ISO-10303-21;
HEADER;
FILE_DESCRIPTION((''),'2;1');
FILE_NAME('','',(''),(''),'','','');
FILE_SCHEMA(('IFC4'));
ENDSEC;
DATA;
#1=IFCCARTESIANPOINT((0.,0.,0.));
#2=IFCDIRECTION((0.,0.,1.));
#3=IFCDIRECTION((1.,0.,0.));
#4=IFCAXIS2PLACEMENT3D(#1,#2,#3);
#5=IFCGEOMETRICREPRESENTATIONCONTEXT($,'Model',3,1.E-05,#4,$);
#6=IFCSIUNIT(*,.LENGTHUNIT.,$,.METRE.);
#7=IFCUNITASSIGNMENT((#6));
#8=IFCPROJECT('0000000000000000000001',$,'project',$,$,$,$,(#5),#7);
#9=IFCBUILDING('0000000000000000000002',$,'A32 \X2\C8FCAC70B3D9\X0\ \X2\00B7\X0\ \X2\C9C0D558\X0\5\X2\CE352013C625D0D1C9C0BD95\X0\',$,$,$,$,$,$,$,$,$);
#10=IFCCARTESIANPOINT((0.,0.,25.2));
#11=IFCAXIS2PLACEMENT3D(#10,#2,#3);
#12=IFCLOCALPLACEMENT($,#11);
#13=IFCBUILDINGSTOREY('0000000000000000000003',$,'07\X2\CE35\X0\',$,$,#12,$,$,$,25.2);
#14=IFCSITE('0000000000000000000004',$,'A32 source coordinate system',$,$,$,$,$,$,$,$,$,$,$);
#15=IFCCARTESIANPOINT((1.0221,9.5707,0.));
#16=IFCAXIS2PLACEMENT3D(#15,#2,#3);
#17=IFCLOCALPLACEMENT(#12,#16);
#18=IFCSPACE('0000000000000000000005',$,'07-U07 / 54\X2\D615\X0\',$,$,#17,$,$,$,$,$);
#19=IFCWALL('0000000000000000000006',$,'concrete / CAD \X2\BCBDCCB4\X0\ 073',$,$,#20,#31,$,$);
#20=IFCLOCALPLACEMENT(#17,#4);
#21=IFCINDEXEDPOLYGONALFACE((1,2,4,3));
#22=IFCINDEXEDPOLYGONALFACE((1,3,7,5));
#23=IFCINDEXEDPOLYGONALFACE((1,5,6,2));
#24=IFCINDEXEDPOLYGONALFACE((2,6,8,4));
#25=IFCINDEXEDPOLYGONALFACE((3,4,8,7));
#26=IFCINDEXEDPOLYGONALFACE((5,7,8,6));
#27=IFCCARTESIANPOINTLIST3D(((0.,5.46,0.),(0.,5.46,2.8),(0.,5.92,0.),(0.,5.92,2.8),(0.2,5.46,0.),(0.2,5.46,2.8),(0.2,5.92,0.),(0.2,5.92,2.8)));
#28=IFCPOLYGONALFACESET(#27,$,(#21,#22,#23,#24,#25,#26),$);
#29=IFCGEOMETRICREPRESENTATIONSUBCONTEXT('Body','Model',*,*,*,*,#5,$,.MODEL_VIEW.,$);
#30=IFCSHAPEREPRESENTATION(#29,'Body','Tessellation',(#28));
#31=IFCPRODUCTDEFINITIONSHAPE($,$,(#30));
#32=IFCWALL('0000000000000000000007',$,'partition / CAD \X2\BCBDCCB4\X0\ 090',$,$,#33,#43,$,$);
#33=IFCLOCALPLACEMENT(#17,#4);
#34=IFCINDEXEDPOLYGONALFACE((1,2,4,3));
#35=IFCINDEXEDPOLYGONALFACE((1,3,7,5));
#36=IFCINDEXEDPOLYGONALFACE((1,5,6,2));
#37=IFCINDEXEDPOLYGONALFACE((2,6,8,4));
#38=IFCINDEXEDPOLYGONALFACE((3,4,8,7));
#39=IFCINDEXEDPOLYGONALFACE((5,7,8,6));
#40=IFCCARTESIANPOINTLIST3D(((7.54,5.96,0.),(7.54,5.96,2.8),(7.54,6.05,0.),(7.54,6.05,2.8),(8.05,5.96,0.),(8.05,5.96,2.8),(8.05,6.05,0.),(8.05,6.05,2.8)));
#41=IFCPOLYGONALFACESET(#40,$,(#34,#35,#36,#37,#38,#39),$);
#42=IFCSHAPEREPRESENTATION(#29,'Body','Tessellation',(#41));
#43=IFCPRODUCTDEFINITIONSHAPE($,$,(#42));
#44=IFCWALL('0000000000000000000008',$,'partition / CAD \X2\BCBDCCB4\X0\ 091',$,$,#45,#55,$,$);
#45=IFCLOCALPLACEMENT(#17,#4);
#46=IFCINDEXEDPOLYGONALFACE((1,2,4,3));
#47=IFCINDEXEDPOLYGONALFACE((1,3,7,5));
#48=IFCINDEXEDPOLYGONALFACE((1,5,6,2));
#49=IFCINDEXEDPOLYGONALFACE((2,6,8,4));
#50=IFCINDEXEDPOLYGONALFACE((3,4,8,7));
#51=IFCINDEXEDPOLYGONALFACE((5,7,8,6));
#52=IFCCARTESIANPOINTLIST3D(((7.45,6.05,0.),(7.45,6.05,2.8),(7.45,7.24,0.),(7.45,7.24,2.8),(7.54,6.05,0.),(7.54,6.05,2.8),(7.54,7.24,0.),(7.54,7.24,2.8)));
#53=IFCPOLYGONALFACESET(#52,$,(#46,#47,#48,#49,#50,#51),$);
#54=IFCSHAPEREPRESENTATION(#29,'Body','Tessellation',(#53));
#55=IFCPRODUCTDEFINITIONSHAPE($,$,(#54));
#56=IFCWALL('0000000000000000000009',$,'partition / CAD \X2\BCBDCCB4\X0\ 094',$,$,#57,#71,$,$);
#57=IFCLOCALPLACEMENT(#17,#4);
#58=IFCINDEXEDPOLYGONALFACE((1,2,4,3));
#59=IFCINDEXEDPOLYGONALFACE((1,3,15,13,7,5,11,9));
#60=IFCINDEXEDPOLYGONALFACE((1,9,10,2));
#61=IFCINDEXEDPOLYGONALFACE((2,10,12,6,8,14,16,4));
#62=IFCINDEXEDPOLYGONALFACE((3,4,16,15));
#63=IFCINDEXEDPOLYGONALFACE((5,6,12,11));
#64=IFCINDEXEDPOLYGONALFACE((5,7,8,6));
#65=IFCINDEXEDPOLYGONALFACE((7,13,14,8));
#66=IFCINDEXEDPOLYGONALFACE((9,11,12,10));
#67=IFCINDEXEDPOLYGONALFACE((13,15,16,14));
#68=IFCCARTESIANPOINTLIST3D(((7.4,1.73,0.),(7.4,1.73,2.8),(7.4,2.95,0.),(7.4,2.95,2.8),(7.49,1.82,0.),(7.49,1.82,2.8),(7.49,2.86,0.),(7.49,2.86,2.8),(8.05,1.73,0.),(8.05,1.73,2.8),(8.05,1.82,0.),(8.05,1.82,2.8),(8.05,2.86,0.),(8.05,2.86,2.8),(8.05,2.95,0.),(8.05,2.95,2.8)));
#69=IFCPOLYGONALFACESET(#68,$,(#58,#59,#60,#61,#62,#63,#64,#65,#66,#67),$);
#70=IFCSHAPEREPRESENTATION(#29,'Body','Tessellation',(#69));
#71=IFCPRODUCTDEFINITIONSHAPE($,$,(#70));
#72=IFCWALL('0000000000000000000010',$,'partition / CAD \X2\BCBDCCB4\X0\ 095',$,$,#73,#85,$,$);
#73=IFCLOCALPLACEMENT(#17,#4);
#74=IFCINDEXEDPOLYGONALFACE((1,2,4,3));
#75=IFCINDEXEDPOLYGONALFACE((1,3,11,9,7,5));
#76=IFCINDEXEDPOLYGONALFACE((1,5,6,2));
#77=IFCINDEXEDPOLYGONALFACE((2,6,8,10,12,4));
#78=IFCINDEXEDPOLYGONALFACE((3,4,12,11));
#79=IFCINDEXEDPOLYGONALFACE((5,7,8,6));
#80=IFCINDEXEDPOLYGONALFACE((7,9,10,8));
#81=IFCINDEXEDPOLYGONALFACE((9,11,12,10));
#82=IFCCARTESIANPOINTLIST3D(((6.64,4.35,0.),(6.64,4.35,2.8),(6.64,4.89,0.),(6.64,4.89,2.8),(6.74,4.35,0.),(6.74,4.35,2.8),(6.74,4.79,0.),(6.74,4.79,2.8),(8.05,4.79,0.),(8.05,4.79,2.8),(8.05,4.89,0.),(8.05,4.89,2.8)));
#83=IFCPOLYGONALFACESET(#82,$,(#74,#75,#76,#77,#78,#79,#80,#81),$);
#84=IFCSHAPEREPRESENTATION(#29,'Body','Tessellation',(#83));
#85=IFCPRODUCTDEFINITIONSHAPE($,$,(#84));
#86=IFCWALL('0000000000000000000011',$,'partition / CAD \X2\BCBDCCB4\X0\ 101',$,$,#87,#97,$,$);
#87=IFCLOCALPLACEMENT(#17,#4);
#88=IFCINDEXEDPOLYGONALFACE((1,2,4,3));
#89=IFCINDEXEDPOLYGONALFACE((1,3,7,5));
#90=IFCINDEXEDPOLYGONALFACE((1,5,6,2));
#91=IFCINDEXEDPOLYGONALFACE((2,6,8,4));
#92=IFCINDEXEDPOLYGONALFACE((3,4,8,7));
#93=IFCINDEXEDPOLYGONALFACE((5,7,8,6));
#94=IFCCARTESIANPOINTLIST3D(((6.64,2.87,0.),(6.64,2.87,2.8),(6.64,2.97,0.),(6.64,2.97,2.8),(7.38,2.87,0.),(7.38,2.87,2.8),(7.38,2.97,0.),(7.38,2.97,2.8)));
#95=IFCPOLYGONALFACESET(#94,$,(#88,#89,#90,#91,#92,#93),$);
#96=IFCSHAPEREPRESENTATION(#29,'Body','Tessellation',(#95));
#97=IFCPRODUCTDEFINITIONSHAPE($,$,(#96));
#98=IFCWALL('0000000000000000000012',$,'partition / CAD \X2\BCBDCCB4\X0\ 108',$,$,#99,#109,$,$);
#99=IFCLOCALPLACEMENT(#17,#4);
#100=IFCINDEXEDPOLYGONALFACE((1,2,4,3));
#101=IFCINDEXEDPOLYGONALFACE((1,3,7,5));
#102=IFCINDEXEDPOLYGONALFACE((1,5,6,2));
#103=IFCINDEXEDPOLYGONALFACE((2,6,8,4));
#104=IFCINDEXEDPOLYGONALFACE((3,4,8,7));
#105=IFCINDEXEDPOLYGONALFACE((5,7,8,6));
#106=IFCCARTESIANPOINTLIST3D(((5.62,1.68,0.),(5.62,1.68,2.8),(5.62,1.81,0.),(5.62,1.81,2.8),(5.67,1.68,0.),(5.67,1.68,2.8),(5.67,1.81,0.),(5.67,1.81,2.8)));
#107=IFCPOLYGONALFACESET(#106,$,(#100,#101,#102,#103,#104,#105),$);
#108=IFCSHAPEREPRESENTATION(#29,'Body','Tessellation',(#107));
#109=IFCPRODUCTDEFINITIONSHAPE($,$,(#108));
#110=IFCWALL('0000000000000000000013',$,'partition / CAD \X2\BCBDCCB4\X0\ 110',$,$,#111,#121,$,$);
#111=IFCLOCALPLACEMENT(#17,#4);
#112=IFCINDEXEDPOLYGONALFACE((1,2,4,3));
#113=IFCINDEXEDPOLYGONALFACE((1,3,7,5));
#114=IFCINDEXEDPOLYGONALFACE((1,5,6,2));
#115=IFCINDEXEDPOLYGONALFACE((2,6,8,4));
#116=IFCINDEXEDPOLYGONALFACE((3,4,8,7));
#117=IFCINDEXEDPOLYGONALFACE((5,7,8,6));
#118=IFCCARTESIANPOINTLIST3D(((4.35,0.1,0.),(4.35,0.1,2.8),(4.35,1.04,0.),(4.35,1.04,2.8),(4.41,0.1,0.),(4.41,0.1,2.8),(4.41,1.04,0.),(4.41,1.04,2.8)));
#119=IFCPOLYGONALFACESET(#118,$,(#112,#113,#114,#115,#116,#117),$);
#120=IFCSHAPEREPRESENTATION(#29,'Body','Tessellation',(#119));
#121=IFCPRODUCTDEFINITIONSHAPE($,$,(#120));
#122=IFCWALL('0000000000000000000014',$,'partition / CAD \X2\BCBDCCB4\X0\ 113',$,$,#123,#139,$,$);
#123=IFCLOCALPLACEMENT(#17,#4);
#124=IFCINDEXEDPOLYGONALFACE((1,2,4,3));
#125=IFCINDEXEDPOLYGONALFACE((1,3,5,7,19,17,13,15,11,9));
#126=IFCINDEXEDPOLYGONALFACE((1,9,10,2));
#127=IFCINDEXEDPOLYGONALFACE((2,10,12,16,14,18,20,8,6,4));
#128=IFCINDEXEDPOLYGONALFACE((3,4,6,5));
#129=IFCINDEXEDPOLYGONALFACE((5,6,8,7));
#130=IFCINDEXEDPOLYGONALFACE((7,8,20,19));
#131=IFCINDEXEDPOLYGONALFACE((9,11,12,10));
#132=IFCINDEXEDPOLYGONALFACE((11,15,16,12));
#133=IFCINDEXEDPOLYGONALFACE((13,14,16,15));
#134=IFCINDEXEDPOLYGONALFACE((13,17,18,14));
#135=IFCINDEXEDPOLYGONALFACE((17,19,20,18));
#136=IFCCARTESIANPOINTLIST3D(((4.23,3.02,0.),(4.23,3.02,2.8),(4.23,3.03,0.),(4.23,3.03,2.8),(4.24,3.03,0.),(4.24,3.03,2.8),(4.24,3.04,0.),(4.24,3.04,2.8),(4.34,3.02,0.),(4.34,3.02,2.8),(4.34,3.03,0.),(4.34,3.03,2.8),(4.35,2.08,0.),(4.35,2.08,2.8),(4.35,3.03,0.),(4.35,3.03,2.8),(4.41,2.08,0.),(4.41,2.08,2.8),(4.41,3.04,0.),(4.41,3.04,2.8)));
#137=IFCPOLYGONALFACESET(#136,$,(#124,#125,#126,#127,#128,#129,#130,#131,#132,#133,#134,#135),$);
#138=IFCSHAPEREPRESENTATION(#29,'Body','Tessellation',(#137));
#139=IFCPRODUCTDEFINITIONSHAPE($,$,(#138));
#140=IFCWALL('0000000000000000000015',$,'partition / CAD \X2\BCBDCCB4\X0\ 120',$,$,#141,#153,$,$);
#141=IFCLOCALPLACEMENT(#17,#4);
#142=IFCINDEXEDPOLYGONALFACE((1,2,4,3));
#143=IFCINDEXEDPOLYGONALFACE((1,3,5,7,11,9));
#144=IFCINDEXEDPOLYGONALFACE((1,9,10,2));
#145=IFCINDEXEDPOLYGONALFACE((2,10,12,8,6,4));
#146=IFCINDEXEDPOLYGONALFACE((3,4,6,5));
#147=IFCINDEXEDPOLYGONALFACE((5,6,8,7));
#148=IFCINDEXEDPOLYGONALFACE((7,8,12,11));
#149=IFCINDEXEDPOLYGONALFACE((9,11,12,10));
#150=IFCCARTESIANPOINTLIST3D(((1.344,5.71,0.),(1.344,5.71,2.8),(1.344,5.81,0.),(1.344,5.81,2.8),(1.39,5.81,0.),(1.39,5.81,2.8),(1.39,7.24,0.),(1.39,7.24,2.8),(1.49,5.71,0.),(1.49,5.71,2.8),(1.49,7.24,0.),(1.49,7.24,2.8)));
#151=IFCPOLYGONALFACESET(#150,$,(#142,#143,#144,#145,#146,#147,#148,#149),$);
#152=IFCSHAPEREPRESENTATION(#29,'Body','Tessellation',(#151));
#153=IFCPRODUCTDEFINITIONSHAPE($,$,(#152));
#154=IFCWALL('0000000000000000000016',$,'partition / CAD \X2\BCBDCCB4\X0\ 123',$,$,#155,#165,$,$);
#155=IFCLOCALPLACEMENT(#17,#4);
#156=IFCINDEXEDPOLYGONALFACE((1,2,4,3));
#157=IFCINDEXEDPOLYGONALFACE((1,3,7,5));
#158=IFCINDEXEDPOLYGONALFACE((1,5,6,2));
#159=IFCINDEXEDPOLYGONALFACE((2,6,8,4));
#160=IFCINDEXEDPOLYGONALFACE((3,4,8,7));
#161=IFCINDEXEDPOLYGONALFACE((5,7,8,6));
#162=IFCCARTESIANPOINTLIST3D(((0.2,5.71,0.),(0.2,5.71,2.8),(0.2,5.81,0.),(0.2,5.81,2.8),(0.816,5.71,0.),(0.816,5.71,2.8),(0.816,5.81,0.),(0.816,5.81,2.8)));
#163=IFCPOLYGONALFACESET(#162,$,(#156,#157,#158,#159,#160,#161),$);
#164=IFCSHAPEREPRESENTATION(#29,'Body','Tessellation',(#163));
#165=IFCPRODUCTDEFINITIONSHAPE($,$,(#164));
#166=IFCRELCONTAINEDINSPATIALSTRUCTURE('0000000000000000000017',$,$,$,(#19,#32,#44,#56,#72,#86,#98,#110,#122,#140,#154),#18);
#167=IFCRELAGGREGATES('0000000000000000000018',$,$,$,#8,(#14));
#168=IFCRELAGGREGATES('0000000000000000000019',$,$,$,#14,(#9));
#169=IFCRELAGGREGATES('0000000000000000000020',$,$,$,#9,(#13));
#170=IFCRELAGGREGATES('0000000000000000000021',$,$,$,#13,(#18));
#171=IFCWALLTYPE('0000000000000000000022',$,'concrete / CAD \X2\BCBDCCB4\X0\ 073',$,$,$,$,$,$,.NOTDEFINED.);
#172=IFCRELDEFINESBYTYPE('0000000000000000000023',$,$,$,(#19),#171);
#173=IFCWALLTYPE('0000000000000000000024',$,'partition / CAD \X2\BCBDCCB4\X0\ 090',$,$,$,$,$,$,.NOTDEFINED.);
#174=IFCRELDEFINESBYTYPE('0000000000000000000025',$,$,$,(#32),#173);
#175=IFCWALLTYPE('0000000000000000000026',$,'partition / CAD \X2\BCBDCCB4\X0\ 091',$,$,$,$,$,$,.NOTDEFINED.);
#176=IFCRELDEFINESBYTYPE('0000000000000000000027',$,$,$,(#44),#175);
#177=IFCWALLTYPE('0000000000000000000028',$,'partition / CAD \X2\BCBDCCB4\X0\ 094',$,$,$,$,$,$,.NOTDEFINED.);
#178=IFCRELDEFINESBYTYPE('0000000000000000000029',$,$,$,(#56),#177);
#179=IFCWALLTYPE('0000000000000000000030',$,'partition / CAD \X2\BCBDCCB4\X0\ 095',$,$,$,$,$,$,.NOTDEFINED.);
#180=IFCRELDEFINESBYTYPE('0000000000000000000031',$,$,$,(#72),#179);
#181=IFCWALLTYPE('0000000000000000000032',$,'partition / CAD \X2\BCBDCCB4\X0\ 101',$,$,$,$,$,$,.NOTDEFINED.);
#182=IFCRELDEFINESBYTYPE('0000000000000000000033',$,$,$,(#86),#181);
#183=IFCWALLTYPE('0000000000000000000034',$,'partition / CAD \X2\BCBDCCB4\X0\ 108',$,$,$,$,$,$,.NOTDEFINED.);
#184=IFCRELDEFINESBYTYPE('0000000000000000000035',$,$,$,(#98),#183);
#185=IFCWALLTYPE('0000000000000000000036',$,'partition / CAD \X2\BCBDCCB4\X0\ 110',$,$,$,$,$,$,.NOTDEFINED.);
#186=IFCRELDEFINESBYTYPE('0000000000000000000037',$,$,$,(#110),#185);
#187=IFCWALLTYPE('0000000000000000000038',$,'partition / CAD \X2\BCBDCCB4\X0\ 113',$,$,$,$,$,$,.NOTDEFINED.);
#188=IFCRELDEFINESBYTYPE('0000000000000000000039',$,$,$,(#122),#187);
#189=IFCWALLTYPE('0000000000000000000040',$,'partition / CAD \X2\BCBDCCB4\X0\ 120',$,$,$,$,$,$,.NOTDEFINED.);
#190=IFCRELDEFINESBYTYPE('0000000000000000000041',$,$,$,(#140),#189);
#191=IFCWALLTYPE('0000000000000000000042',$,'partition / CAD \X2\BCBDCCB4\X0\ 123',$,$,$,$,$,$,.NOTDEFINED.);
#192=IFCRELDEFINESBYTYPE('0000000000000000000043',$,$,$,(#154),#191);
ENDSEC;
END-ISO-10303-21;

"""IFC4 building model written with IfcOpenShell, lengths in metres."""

from ifc_helpers import new_model, si_unit, frame, origin, origin_with_axes, place, context, subcontext, project, spatial, polyline, outline, extrude, source, transform, mapped, type_object, type_shapes, element, save


model = new_model("IFC4")

# Units and contexts
model_context = context("Model", 3, precision=1e-05, world=origin_with_axes())
body_context = subcontext(model_context, "Body", "Model", "MODEL_VIEW")
ifc_project = project(units=[si_unit("LENGTHUNIT", "METRE")], contexts=[model_context])

# Site, building, storey, space
site = spatial("IfcSite", under=ifc_project, Name="A32 source coordinate system")
building = spatial("IfcBuilding", under=site, Name="A32 주거동 · 지하5층–옥탑지붕")
storey_placement = place(None, frame((0.0, 0.0, 25.2), z_axis=(0.0, 0.0, 1.0), x_axis=(1.0, 0.0, 0.0)))
storey = spatial("IfcBuildingStorey", under=building, at=storey_placement, Name="07층", Elevation=25.2)
space_1_placement = place(storey_placement, frame((1.0221, 9.5707, 0.0), z_axis=(0.0, 0.0, 1.0), x_axis=(1.0, 0.0, 0.0)))
space_1 = spatial("IfcSpace", under=storey, at=space_1_placement, Name="07-U07 / 54형")

# Walls
wall_type_1 = type_object("IfcWallType", Name="concrete / CAD 벽체 073", PredefinedType="NOTDEFINED")
shared_shape_1 = source(origin(), body_context, "Body", "SweptSolid", [
    extrude(outline(polyline([(0.2, 5.92), (0.2, 5.46), (0.0, 5.46), (0.0, 5.92), (0.2, 5.92)])), origin(), (0.0, 0.0, 1.0), 2.8),
])
type_shapes(wall_type_1, [shared_shape_1])
wall_1_placement = place(space_1_placement, origin_with_axes())
element("IfcWall", 1, at=wall_1_placement, inside=space_1, type_object=wall_type_1, Name="concrete / CAD 벽체 073", context=body_context, shape_type="MappedRepresentation", body=[
    mapped(shared_shape_1, transform((0.0, 0.0, 0.0), scale=1.0)),
])
wall_type_2 = type_object("IfcWallType", Name="partition / CAD 벽체 090", PredefinedType="NOTDEFINED")
shared_shape_2 = source(origin(), body_context, "Body", "SweptSolid", [
    extrude(outline(polyline([(7.54, 5.96), (7.54, 6.05), (8.05, 6.05), (8.05, 5.96), (7.54, 5.96)])), origin(), (0.0, 0.0, 1.0), 2.8),
])
type_shapes(wall_type_2, [shared_shape_2])
wall_2_placement = place(space_1_placement, origin_with_axes())
element("IfcWall", 2, at=wall_2_placement, inside=space_1, type_object=wall_type_2, Name="partition / CAD 벽체 090", context=body_context, shape_type="MappedRepresentation", body=[
    mapped(shared_shape_2, transform((0.0, 0.0, 0.0), scale=1.0)),
])
wall_type_3 = type_object("IfcWallType", Name="partition / CAD 벽체 091", PredefinedType="NOTDEFINED")
shared_shape_3 = source(origin(), body_context, "Body", "SweptSolid", [
    extrude(outline(polyline([(7.54, 6.05), (7.45, 6.05), (7.45, 7.24), (7.54, 7.24), (7.54, 6.05)])), origin(), (0.0, 0.0, 1.0), 2.8),
])
type_shapes(wall_type_3, [shared_shape_3])
wall_3_placement = place(space_1_placement, origin_with_axes())
element("IfcWall", 3, at=wall_3_placement, inside=space_1, type_object=wall_type_3, Name="partition / CAD 벽체 091", context=body_context, shape_type="MappedRepresentation", body=[
    mapped(shared_shape_3, transform((0.0, 0.0, 0.0), scale=1.0)),
])
wall_type_4 = type_object("IfcWallType", Name="partition / CAD 벽체 094", PredefinedType="NOTDEFINED")
shared_shape_4 = source(origin(), body_context, "Body", "SweptSolid", [
    extrude(outline(polyline([(8.05, 1.73), (7.4, 1.73), (7.4, 2.95), (8.05, 2.95), (8.05, 2.86), (7.49, 2.86), (7.49, 1.82), (8.05, 1.82), (8.05, 1.73)])), origin(), (0.0, 0.0, 1.0), 2.8),
])
type_shapes(wall_type_4, [shared_shape_4])
wall_4_placement = place(space_1_placement, origin_with_axes())
element("IfcWall", 4, at=wall_4_placement, inside=space_1, type_object=wall_type_4, Name="partition / CAD 벽체 094", context=body_context, shape_type="MappedRepresentation", body=[
    mapped(shared_shape_4, transform((0.0, 0.0, 0.0), scale=1.0)),
])
wall_type_5 = type_object("IfcWallType", Name="partition / CAD 벽체 095", PredefinedType="NOTDEFINED")
shared_shape_5 = source(origin(), body_context, "Body", "SweptSolid", [
    extrude(outline(polyline([(6.64, 4.89), (8.05, 4.89), (8.05, 4.79), (6.74, 4.79), (6.74, 4.35), (6.64, 4.35), (6.64, 4.89)])), origin(), (0.0, 0.0, 1.0), 2.8),
])
type_shapes(wall_type_5, [shared_shape_5])
wall_5_placement = place(space_1_placement, origin_with_axes())
element("IfcWall", 5, at=wall_5_placement, inside=space_1, type_object=wall_type_5, Name="partition / CAD 벽체 095", context=body_context, shape_type="MappedRepresentation", body=[
    mapped(shared_shape_5, transform((0.0, 0.0, 0.0), scale=1.0)),
])
wall_type_6 = type_object("IfcWallType", Name="partition / CAD 벽체 101", PredefinedType="NOTDEFINED")
shared_shape_6 = source(origin(), body_context, "Body", "SweptSolid", [
    extrude(outline(polyline([(7.38, 2.97), (7.38, 2.87), (6.64, 2.87), (6.64, 2.97), (7.38, 2.97)])), origin(), (0.0, 0.0, 1.0), 2.8),
])
type_shapes(wall_type_6, [shared_shape_6])
wall_6_placement = place(space_1_placement, origin_with_axes())
element("IfcWall", 6, at=wall_6_placement, inside=space_1, type_object=wall_type_6, Name="partition / CAD 벽체 101", context=body_context, shape_type="MappedRepresentation", body=[
    mapped(shared_shape_6, transform((0.0, 0.0, 0.0), scale=1.0)),
])
wall_type_7 = type_object("IfcWallType", Name="partition / CAD 벽체 108", PredefinedType="NOTDEFINED")
shared_shape_7 = source(origin(), body_context, "Body", "SweptSolid", [
    extrude(outline(polyline([(5.67, 1.68), (5.62, 1.68), (5.62, 1.81), (5.67, 1.81), (5.67, 1.68)])), origin(), (0.0, 0.0, 1.0), 2.8),
])
type_shapes(wall_type_7, [shared_shape_7])
wall_7_placement = place(space_1_placement, origin_with_axes())
element("IfcWall", 7, at=wall_7_placement, inside=space_1, type_object=wall_type_7, Name="partition / CAD 벽체 108", context=body_context, shape_type="MappedRepresentation", body=[
    mapped(shared_shape_7, transform((0.0, 0.0, 0.0), scale=1.0)),
])
wall_type_8 = type_object("IfcWallType", Name="partition / CAD 벽체 110", PredefinedType="NOTDEFINED")
shared_shape_8 = source(origin(), body_context, "Body", "SweptSolid", [
    extrude(outline(polyline([(4.35, 1.04), (4.41, 1.04), (4.41, 0.1), (4.35, 0.1), (4.35, 1.04)])), origin(), (0.0, 0.0, 1.0), 2.8),
])
type_shapes(wall_type_8, [shared_shape_8])
wall_8_placement = place(space_1_placement, origin_with_axes())
element("IfcWall", 8, at=wall_8_placement, inside=space_1, type_object=wall_type_8, Name="partition / CAD 벽체 110", context=body_context, shape_type="MappedRepresentation", body=[
    mapped(shared_shape_8, transform((0.0, 0.0, 0.0), scale=1.0)),
])
wall_type_9 = type_object("IfcWallType", Name="partition / CAD 벽체 113", PredefinedType="NOTDEFINED")
shared_shape_9 = source(origin(), body_context, "Body", "SweptSolid", [
    extrude(outline(polyline([(4.24, 3.04), (4.41, 3.04), (4.41, 2.08), (4.35, 2.08), (4.35, 3.03), (4.34, 3.03), (4.34, 3.02), (4.23, 3.02), (4.23, 3.03), (4.24, 3.03), (4.24, 3.04)])), origin(), (0.0, 0.0, 1.0), 2.8),
])
type_shapes(wall_type_9, [shared_shape_9])
wall_9_placement = place(space_1_placement, origin_with_axes())
element("IfcWall", 9, at=wall_9_placement, inside=space_1, type_object=wall_type_9, Name="partition / CAD 벽체 113", context=body_context, shape_type="MappedRepresentation", body=[
    mapped(shared_shape_9, transform((0.0, 0.0, 0.0), scale=1.0)),
])
wall_type_10 = type_object("IfcWallType", Name="partition / CAD 벽체 120", PredefinedType="NOTDEFINED")
shared_shape_10 = source(origin(), body_context, "Body", "SweptSolid", [
    extrude(outline(polyline([(1.39, 7.24), (1.49, 7.24), (1.49, 5.71), (1.344, 5.71), (1.344, 5.81), (1.39, 5.81), (1.39, 7.24)])), origin(), (0.0, 0.0, 1.0), 2.8),
])
type_shapes(wall_type_10, [shared_shape_10])
wall_10_placement = place(space_1_placement, origin_with_axes())
element("IfcWall", 10, at=wall_10_placement, inside=space_1, type_object=wall_type_10, Name="partition / CAD 벽체 120", context=body_context, shape_type="MappedRepresentation", body=[
    mapped(shared_shape_10, transform((0.0, 0.0, 0.0), scale=1.0)),
])
wall_type_11 = type_object("IfcWallType", Name="partition / CAD 벽체 123", PredefinedType="NOTDEFINED")
shared_shape_11 = source(origin(), body_context, "Body", "SweptSolid", [
    extrude(outline(polyline([(0.816, 5.81), (0.816, 5.71), (0.2, 5.71), (0.2, 5.81), (0.816, 5.81)])), origin(), (0.0, 0.0, 1.0), 2.8),
])
type_shapes(wall_type_11, [shared_shape_11])
wall_11_placement = place(space_1_placement, origin_with_axes())
element("IfcWall", 11, at=wall_11_placement, inside=space_1, type_object=wall_type_11, Name="partition / CAD 벽체 123", context=body_context, shape_type="MappedRepresentation", body=[
    mapped(shared_shape_11, transform((0.0, 0.0, 0.0), scale=1.0)),
])

save(model, "model.ifc")
